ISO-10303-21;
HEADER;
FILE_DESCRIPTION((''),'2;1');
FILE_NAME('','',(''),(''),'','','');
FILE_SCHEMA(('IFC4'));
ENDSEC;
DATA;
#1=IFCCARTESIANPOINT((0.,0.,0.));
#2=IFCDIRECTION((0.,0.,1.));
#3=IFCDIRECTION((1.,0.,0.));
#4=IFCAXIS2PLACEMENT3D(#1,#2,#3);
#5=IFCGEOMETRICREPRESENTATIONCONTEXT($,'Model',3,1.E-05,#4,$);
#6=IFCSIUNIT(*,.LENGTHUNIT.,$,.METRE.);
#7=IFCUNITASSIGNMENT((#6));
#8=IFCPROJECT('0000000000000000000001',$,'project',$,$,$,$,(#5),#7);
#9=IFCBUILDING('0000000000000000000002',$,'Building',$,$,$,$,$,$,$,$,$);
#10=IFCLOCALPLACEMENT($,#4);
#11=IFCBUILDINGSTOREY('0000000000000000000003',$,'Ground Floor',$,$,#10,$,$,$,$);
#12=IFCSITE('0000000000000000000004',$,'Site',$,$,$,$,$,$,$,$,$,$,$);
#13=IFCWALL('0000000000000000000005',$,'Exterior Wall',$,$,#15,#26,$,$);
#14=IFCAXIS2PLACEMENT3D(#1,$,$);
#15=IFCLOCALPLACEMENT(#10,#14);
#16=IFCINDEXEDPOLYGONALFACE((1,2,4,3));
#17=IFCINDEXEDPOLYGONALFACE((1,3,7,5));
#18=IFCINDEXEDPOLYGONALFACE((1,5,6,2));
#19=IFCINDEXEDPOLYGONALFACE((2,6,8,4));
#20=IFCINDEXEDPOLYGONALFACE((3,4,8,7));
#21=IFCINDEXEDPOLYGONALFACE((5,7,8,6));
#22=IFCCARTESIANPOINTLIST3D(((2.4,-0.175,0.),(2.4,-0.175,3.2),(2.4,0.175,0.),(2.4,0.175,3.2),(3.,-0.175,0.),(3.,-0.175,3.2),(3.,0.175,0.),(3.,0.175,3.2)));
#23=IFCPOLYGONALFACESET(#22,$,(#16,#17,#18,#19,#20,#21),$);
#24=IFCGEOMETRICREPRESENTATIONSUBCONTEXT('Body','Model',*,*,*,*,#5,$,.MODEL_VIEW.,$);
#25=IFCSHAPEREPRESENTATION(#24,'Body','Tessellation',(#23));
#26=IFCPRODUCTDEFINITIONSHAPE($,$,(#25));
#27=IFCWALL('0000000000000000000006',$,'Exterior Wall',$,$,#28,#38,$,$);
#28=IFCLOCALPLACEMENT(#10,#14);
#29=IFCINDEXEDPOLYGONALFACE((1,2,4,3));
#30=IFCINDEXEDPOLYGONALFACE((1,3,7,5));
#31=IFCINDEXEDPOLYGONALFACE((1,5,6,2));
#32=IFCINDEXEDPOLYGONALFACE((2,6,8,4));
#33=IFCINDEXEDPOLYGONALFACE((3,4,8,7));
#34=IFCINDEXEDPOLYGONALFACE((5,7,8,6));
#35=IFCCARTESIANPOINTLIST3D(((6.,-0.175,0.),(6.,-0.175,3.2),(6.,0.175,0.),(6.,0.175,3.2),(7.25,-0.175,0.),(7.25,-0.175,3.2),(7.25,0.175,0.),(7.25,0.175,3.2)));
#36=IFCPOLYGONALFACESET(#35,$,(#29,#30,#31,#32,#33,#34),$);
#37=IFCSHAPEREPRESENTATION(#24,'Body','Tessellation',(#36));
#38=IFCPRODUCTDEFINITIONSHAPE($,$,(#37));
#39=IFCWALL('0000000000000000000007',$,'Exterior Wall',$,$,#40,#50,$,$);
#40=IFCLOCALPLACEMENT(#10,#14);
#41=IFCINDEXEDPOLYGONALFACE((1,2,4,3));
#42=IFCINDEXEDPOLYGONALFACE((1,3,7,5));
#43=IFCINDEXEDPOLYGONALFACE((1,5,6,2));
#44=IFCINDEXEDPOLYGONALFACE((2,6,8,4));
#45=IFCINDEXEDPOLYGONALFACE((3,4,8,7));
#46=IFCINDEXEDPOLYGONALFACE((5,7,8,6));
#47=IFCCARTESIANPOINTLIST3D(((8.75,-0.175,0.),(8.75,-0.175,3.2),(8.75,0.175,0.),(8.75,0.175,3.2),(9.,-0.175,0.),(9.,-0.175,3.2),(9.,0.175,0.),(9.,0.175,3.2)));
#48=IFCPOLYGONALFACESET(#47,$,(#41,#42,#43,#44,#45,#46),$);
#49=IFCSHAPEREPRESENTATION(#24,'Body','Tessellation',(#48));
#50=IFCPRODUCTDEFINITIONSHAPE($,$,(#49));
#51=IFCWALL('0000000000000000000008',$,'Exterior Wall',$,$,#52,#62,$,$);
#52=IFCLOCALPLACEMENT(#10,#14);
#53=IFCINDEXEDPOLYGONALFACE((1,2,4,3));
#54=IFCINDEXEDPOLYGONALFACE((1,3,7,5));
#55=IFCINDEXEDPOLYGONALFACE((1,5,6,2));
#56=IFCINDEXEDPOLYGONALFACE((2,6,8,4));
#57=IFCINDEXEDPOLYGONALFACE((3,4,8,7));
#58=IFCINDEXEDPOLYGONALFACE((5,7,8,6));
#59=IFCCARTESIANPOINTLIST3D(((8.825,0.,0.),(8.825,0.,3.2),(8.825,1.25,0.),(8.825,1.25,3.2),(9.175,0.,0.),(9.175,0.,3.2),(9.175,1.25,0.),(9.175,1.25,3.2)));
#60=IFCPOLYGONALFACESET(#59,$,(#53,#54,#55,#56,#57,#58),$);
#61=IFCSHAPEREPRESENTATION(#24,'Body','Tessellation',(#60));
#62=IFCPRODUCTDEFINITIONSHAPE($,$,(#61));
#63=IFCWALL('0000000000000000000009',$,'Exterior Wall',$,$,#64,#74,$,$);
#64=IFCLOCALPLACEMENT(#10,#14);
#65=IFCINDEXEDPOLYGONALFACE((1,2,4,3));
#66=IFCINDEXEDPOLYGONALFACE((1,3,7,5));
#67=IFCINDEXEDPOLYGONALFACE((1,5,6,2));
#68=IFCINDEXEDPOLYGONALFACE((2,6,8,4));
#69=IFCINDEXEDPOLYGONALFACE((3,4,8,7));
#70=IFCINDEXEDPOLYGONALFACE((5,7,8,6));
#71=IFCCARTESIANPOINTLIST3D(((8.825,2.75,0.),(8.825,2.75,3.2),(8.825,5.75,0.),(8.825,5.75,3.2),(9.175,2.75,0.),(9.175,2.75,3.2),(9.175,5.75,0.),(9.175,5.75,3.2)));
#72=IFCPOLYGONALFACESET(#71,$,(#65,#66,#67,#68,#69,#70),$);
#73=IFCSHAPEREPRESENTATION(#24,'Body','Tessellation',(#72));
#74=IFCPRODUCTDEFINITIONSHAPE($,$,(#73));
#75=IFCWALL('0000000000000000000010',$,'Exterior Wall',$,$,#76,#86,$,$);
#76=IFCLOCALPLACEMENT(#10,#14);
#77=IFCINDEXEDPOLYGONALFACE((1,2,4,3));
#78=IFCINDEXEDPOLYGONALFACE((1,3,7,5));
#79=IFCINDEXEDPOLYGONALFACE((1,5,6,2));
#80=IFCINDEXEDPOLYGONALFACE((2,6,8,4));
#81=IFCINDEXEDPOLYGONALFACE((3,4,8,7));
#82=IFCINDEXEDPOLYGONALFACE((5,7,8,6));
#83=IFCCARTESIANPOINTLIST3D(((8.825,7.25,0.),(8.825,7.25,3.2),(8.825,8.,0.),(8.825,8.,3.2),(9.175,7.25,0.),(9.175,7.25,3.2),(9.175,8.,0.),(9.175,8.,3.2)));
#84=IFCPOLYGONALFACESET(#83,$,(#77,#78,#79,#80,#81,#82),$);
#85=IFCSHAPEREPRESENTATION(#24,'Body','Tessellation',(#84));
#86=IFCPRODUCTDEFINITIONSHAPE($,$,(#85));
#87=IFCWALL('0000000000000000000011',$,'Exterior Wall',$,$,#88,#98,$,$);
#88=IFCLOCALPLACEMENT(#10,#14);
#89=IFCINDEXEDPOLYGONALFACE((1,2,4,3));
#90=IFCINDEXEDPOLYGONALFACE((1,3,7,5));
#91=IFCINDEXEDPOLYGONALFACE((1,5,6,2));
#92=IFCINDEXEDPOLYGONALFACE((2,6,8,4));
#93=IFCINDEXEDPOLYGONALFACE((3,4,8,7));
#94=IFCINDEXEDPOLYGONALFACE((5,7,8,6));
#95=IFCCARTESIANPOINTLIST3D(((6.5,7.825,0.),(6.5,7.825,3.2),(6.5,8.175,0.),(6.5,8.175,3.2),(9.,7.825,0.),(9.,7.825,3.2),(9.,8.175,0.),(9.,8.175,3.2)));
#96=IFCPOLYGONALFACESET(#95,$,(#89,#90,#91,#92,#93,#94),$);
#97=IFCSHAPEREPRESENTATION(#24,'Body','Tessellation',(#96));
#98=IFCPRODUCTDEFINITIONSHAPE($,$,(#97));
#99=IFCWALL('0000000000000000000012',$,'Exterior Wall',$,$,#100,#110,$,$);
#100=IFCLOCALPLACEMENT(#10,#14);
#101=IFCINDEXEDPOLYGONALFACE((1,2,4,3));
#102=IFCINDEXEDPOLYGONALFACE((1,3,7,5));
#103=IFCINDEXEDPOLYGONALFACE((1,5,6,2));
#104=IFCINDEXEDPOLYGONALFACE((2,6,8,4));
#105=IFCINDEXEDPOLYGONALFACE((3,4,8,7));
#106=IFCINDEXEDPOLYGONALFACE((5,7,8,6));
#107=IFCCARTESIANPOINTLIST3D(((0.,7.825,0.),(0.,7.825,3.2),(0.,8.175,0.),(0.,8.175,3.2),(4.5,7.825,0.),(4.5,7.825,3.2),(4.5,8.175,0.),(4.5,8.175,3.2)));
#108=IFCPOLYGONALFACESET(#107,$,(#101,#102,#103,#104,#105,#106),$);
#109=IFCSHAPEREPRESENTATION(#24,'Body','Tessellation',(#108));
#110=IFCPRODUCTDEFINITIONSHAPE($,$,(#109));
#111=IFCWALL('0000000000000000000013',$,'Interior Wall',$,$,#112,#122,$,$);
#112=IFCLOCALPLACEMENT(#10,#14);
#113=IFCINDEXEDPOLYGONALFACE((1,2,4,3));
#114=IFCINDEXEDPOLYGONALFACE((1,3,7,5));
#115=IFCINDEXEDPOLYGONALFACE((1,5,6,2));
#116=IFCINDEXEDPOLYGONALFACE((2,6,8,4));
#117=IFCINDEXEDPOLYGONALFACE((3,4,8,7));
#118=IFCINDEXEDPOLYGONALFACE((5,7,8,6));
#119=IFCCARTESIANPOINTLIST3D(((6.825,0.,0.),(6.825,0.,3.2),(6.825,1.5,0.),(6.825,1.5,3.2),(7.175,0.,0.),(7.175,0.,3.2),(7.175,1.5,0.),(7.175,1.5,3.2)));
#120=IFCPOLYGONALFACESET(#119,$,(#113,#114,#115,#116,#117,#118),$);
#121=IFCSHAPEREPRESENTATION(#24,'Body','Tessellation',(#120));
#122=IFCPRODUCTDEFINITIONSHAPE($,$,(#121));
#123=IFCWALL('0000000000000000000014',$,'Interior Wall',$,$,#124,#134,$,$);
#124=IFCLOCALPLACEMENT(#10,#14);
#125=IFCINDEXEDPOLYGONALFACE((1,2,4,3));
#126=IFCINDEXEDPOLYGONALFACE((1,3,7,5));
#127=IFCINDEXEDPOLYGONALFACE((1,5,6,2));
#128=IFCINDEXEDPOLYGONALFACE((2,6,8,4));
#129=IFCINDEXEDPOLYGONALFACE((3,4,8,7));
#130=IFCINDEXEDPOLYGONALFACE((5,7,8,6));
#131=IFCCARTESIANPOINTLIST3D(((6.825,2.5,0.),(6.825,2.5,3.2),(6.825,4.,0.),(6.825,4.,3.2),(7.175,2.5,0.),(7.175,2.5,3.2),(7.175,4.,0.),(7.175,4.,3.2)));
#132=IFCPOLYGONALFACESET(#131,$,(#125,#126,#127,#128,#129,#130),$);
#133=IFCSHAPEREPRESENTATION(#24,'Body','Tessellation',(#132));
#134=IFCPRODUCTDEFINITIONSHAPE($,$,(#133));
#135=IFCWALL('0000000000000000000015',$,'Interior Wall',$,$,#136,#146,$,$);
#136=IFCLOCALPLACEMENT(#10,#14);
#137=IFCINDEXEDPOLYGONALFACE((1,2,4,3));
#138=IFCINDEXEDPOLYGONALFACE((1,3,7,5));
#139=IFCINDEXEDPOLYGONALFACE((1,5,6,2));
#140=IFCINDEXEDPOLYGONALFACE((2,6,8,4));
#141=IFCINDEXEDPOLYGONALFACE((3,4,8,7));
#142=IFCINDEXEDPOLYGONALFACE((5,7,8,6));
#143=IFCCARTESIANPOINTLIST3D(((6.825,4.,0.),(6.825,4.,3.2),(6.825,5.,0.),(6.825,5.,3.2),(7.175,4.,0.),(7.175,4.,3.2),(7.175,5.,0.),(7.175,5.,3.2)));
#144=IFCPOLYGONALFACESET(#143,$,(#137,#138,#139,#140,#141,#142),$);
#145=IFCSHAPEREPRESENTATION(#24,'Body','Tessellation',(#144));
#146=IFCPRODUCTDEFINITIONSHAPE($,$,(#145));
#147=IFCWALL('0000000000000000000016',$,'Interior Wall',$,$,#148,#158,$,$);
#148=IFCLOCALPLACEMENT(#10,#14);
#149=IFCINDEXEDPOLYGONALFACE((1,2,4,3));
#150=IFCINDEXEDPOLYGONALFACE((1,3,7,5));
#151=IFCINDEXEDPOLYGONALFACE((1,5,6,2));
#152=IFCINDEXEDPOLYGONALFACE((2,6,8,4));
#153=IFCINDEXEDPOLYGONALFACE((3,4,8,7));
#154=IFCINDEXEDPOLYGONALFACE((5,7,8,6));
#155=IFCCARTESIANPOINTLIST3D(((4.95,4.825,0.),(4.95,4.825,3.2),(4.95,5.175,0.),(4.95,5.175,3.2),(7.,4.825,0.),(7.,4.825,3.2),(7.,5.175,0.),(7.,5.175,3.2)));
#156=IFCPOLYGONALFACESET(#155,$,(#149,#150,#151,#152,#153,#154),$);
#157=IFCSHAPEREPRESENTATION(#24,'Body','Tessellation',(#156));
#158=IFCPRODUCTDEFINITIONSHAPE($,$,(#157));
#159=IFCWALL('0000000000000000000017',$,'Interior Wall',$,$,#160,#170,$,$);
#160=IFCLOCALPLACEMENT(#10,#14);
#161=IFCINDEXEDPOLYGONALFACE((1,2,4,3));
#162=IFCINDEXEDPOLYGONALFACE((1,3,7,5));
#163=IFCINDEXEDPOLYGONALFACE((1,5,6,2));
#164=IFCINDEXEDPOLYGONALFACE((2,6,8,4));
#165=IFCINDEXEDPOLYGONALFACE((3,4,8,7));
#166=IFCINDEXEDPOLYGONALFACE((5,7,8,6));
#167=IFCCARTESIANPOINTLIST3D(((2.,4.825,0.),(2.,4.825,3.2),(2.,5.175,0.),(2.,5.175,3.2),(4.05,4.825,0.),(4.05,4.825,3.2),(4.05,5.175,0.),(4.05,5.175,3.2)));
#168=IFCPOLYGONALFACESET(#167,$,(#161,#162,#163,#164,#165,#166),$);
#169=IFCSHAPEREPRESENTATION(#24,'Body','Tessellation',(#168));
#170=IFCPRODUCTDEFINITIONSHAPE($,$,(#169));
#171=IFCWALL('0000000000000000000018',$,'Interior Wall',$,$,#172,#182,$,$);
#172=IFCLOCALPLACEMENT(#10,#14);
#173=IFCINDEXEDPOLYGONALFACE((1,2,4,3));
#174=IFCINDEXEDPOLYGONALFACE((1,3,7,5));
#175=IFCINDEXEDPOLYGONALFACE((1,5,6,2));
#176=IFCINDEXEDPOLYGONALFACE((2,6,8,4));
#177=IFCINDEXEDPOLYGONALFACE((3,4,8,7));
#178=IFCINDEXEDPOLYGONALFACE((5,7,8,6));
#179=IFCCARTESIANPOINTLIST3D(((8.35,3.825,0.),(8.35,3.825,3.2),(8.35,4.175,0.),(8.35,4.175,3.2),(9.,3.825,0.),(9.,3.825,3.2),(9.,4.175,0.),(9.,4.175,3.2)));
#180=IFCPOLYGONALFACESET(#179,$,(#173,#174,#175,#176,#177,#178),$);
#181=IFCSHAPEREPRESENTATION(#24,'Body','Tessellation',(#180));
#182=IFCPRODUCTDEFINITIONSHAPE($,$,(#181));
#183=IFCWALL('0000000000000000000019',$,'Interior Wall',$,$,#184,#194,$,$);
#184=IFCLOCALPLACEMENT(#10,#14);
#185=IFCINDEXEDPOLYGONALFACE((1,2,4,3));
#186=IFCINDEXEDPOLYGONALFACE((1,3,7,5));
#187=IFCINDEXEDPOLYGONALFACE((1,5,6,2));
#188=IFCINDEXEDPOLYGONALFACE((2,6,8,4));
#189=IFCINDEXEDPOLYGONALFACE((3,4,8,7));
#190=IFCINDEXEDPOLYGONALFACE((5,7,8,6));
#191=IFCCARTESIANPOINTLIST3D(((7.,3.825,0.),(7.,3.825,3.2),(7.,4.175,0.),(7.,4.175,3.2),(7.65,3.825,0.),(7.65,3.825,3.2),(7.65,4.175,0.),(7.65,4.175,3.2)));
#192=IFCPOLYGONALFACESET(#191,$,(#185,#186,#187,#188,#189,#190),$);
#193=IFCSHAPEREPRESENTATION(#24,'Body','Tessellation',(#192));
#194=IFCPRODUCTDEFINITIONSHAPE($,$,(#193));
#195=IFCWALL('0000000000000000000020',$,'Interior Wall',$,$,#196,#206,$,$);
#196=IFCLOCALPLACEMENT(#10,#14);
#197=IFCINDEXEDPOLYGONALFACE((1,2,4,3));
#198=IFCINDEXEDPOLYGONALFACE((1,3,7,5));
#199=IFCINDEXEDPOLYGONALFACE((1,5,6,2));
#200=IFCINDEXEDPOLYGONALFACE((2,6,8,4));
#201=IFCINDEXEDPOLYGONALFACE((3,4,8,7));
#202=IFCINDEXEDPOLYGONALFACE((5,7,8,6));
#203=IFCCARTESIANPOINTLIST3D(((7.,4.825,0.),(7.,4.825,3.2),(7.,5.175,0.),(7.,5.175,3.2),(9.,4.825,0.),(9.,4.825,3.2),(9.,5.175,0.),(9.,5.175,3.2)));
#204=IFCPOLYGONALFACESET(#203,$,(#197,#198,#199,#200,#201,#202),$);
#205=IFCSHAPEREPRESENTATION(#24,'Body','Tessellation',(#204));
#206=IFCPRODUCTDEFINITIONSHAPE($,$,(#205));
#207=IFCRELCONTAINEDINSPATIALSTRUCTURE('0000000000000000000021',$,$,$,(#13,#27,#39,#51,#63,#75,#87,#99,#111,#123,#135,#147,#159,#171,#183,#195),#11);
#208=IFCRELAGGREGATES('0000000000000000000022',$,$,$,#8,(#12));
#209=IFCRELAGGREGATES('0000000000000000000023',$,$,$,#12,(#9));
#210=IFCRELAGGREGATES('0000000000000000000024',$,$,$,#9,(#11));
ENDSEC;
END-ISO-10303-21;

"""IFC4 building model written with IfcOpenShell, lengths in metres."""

from ifc_helpers import new_model, si_unit, frame, origin_with_axes, place, context, subcontext, project, spatial, indexed_curve, outline, extrude, element, save


model = new_model("IFC4")

# Units and contexts
model_context = context("Model", 3, precision=1e-05, world=origin_with_axes())
body_context = subcontext(model_context, "Body", "Model", "MODEL_VIEW")
ifc_project = project(units=[si_unit("LENGTHUNIT", "METRE")], contexts=[model_context])

# Site, building, storey
site = spatial("IfcSite", under=ifc_project, Name="Site")
building = spatial("IfcBuilding", under=site, Name="Building")
storey_placement = place(None, origin_with_axes())
storey = spatial("IfcBuildingStorey", under=building, at=storey_placement, Name="Ground Floor")

# Walls
wall_1_placement = place(storey_placement, frame((2.4, 0.0, 0.0), z_axis=(0.0, 0.0, 1.0), x_axis=(1.0, 0.0, 0.0)))
element("IfcWall", 1, at=wall_1_placement, inside=storey, Name="Exterior Wall", context=body_context, shape_type="SweptSolid", body=[
    extrude(outline(indexed_curve([(0.0, 0.0), (0.0, 0.35), (0.6, 0.35), (0.6, 0.0), (0.0, 0.0)], self_intersect=False)), frame((0.0, -0.175, 0.0), z_axis=(0.0, 0.0, 1.0), x_axis=(1.0, 0.0, 0.0)), (0.0, 0.0, 1.0), 3.2),
])
wall_2_placement = place(storey_placement, frame((6.0, 0.0, 0.0), z_axis=(0.0, 0.0, 1.0), x_axis=(1.0, 0.0, 0.0)))
element("IfcWall", 2, at=wall_2_placement, inside=storey, Name="Exterior Wall", context=body_context, shape_type="SweptSolid", body=[
    extrude(outline(indexed_curve([(0.0, 0.0), (0.0, 0.35), (1.25, 0.35), (1.25, 0.0), (0.0, 0.0)], self_intersect=False)), frame((0.0, -0.175, 0.0), z_axis=(0.0, 0.0, 1.0), x_axis=(1.0, 0.0, 0.0)), (0.0, 0.0, 1.0), 3.2),
])
wall_3_placement = place(storey_placement, frame((8.75, 0.0, 0.0), z_axis=(0.0, 0.0, 1.0), x_axis=(1.0, 0.0, 0.0)))
element("IfcWall", 3, at=wall_3_placement, inside=storey, Name="Exterior Wall", context=body_context, shape_type="SweptSolid", body=[
    extrude(outline(indexed_curve([(0.0, 0.0), (0.0, 0.35), (0.25, 0.35), (0.25, 0.0), (0.0, 0.0)], self_intersect=False)), frame((0.0, -0.175, 0.0), z_axis=(0.0, 0.0, 1.0), x_axis=(1.0, 0.0, 0.0)), (0.0, 0.0, 1.0), 3.2),
])
wall_4_placement = place(storey_placement, frame((9.0, 0.0, 0.0), z_axis=(0.0, 0.0, 1.0), x_axis=(0.0, 1.0, 0.0)))
element("IfcWall", 4, at=wall_4_placement, inside=storey, Name="Exterior Wall", context=body_context, shape_type="SweptSolid", body=[
    extrude(outline(indexed_curve([(0.0, 0.0), (0.0, 0.35), (1.25, 0.35), (1.25, 0.0), (0.0, 0.0)], self_intersect=False)), frame((0.0, -0.175, 0.0), z_axis=(0.0, 0.0, 1.0), x_axis=(1.0, 0.0, 0.0)), (0.0, 0.0, 1.0), 3.2),
])
wall_5_placement = place(storey_placement, frame((9.0, 2.75, 0.0), z_axis=(0.0, 0.0, 1.0), x_axis=(0.0, 1.0, 0.0)))
element("IfcWall", 5, at=wall_5_placement, inside=storey, Name="Exterior Wall", context=body_context, shape_type="SweptSolid", body=[
    extrude(outline(indexed_curve([(0.0, 0.0), (0.0, 0.35), (3.0, 0.35), (3.0, 0.0), (0.0, 0.0)], self_intersect=False)), frame((0.0, -0.175, 0.0), z_axis=(0.0, 0.0, 1.0), x_axis=(1.0, 0.0, 0.0)), (0.0, 0.0, 1.0), 3.2),
])
wall_6_placement = place(storey_placement, frame((9.0, 7.25, 0.0), z_axis=(0.0, 0.0, 1.0), x_axis=(0.0, 1.0, 0.0)))
element("IfcWall", 6, at=wall_6_placement, inside=storey, Name="Exterior Wall", context=body_context, shape_type="SweptSolid", body=[
    extrude(outline(indexed_curve([(0.0, 0.0), (0.0, 0.35), (0.75, 0.35), (0.75, 0.0), (0.0, 0.0)], self_intersect=False)), frame((0.0, -0.175, 0.0), z_axis=(0.0, 0.0, 1.0), x_axis=(1.0, 0.0, 0.0)), (0.0, 0.0, 1.0), 3.2),
])
wall_7_placement = place(storey_placement, frame((9.0, 8.0, 0.0), z_axis=(0.0, 0.0, 1.0), x_axis=(-1.0, 0.0, 0.0)))
element("IfcWall", 7, at=wall_7_placement, inside=storey, Name="Exterior Wall", context=body_context, shape_type="SweptSolid", body=[
    extrude(outline(indexed_curve([(0.0, 0.0), (0.0, 0.35), (2.5, 0.35), (2.5, 0.0), (0.0, 0.0)], self_intersect=False)), frame((0.0, -0.175, 0.0), z_axis=(0.0, 0.0, 1.0), x_axis=(1.0, 0.0, 0.0)), (0.0, 0.0, 1.0), 3.2),
])
wall_8_placement = place(storey_placement, frame((4.5, 8.0, 0.0), z_axis=(0.0, 0.0, 1.0), x_axis=(-1.0, 0.0, 0.0)))
element("IfcWall", 8, at=wall_8_placement, inside=storey, Name="Exterior Wall", context=body_context, shape_type="SweptSolid", body=[
    extrude(outline(indexed_curve([(0.0, 0.0), (0.0, 0.35), (4.5, 0.35), (4.5, 0.0), (0.0, 0.0)], self_intersect=False)), frame((0.0, -0.175, 0.0), z_axis=(0.0, 0.0, 1.0), x_axis=(1.0, 0.0, 0.0)), (0.0, 0.0, 1.0), 3.2),
])
for number, where, z_axis, x_axis, name in (
    (9, (7.0, 0.0, 0.0), (0.0, 0.0, 1.0), (0.0, 1.0, 0.0), "Interior Wall"),
    (10, (7.0, 2.5, 0.0), (0.0, 0.0, 1.0), (0.0, 1.0, 0.0), "Interior Wall"),
):
    element("IfcWall", number, at=place(storey_placement, frame(where, z_axis=z_axis, x_axis=x_axis)), inside=storey, Name=name, context=body_context, shape_type="SweptSolid", body=[
        extrude(outline(indexed_curve([(0.0, 0.0), (0.0, 0.35), (1.5, 0.35), (1.5, 0.0), (0.0, 0.0)], self_intersect=False)), frame((0.0, -0.175, 0.0), z_axis=(0.0, 0.0, 1.0), x_axis=(1.0, 0.0, 0.0)), (0.0, 0.0, 1.0), 3.2),
    ])
wall_9_placement = place(storey_placement, frame((7.0, 4.0, 0.0), z_axis=(0.0, 0.0, 1.0), x_axis=(0.0, 1.0, 0.0)))
element("IfcWall", 11, at=wall_9_placement, inside=storey, Name="Interior Wall", context=body_context, shape_type="SweptSolid", body=[
    extrude(outline(indexed_curve([(0.0, 0.0), (0.0, 0.35), (1.0, 0.35), (1.0, 0.0), (0.0, 0.0)], self_intersect=False)), frame((0.0, -0.175, 0.0), z_axis=(0.0, 0.0, 1.0), x_axis=(1.0, 0.0, 0.0)), (0.0, 0.0, 1.0), 3.2),
])
for number, where, z_axis, x_axis, name in (
    (12, (7.0, 5.0, 0.0), (0.0, 0.0, 1.0), (-1.0, 0.0, 0.0), "Interior Wall"),
    (13, (4.05, 5.0, 0.0), (0.0, 0.0, 1.0), (-1.0, 0.0, 0.0), "Interior Wall"),
):
    element("IfcWall", number, at=place(storey_placement, frame(where, z_axis=z_axis, x_axis=x_axis)), inside=storey, Name=name, context=body_context, shape_type="SweptSolid", body=[
        extrude(outline(indexed_curve([(0.0, 0.0), (0.0, 0.35), (2.05, 0.35), (2.05, 0.0), (0.0, 0.0)], self_intersect=False)), frame((0.0, -0.175, 0.0), z_axis=(0.0, 0.0, 1.0), x_axis=(1.0, 0.0, 0.0)), (0.0, 0.0, 1.0), 3.2),
    ])
for number, where, z_axis, x_axis, name in (
    (14, (9.0, 4.0, 0.0), (0.0, 0.0, 1.0), (-1.0, 0.0, 0.0), "Interior Wall"),
    (15, (7.65, 4.0, 0.0), (0.0, 0.0, 1.0), (-1.0, 0.0, 0.0), "Interior Wall"),
):
    element("IfcWall", number, at=place(storey_placement, frame(where, z_axis=z_axis, x_axis=x_axis)), inside=storey, Name=name, context=body_context, shape_type="SweptSolid", body=[
        extrude(outline(indexed_curve([(0.0, 0.0), (0.0, 0.35), (0.65, 0.35), (0.65, 0.0), (0.0, 0.0)], self_intersect=False)), frame((0.0, -0.175, 0.0), z_axis=(0.0, 0.0, 1.0), x_axis=(1.0, 0.0, 0.0)), (0.0, 0.0, 1.0), 3.2),
    ])
wall_10_placement = place(storey_placement, frame((9.0, 5.0, 0.0), z_axis=(0.0, 0.0, 1.0), x_axis=(-1.0, 0.0, 0.0)))
element("IfcWall", 16, at=wall_10_placement, inside=storey, Name="Interior Wall", context=body_context, shape_type="SweptSolid", body=[
    extrude(outline(indexed_curve([(0.0, 0.0), (0.0, 0.35), (2.0, 0.35), (2.0, 0.0), (0.0, 0.0)], self_intersect=False)), frame((0.0, -0.175, 0.0), z_axis=(0.0, 0.0, 1.0), x_axis=(1.0, 0.0, 0.0)), (0.0, 0.0, 1.0), 3.2),
])

save(model, "model.ifc")
